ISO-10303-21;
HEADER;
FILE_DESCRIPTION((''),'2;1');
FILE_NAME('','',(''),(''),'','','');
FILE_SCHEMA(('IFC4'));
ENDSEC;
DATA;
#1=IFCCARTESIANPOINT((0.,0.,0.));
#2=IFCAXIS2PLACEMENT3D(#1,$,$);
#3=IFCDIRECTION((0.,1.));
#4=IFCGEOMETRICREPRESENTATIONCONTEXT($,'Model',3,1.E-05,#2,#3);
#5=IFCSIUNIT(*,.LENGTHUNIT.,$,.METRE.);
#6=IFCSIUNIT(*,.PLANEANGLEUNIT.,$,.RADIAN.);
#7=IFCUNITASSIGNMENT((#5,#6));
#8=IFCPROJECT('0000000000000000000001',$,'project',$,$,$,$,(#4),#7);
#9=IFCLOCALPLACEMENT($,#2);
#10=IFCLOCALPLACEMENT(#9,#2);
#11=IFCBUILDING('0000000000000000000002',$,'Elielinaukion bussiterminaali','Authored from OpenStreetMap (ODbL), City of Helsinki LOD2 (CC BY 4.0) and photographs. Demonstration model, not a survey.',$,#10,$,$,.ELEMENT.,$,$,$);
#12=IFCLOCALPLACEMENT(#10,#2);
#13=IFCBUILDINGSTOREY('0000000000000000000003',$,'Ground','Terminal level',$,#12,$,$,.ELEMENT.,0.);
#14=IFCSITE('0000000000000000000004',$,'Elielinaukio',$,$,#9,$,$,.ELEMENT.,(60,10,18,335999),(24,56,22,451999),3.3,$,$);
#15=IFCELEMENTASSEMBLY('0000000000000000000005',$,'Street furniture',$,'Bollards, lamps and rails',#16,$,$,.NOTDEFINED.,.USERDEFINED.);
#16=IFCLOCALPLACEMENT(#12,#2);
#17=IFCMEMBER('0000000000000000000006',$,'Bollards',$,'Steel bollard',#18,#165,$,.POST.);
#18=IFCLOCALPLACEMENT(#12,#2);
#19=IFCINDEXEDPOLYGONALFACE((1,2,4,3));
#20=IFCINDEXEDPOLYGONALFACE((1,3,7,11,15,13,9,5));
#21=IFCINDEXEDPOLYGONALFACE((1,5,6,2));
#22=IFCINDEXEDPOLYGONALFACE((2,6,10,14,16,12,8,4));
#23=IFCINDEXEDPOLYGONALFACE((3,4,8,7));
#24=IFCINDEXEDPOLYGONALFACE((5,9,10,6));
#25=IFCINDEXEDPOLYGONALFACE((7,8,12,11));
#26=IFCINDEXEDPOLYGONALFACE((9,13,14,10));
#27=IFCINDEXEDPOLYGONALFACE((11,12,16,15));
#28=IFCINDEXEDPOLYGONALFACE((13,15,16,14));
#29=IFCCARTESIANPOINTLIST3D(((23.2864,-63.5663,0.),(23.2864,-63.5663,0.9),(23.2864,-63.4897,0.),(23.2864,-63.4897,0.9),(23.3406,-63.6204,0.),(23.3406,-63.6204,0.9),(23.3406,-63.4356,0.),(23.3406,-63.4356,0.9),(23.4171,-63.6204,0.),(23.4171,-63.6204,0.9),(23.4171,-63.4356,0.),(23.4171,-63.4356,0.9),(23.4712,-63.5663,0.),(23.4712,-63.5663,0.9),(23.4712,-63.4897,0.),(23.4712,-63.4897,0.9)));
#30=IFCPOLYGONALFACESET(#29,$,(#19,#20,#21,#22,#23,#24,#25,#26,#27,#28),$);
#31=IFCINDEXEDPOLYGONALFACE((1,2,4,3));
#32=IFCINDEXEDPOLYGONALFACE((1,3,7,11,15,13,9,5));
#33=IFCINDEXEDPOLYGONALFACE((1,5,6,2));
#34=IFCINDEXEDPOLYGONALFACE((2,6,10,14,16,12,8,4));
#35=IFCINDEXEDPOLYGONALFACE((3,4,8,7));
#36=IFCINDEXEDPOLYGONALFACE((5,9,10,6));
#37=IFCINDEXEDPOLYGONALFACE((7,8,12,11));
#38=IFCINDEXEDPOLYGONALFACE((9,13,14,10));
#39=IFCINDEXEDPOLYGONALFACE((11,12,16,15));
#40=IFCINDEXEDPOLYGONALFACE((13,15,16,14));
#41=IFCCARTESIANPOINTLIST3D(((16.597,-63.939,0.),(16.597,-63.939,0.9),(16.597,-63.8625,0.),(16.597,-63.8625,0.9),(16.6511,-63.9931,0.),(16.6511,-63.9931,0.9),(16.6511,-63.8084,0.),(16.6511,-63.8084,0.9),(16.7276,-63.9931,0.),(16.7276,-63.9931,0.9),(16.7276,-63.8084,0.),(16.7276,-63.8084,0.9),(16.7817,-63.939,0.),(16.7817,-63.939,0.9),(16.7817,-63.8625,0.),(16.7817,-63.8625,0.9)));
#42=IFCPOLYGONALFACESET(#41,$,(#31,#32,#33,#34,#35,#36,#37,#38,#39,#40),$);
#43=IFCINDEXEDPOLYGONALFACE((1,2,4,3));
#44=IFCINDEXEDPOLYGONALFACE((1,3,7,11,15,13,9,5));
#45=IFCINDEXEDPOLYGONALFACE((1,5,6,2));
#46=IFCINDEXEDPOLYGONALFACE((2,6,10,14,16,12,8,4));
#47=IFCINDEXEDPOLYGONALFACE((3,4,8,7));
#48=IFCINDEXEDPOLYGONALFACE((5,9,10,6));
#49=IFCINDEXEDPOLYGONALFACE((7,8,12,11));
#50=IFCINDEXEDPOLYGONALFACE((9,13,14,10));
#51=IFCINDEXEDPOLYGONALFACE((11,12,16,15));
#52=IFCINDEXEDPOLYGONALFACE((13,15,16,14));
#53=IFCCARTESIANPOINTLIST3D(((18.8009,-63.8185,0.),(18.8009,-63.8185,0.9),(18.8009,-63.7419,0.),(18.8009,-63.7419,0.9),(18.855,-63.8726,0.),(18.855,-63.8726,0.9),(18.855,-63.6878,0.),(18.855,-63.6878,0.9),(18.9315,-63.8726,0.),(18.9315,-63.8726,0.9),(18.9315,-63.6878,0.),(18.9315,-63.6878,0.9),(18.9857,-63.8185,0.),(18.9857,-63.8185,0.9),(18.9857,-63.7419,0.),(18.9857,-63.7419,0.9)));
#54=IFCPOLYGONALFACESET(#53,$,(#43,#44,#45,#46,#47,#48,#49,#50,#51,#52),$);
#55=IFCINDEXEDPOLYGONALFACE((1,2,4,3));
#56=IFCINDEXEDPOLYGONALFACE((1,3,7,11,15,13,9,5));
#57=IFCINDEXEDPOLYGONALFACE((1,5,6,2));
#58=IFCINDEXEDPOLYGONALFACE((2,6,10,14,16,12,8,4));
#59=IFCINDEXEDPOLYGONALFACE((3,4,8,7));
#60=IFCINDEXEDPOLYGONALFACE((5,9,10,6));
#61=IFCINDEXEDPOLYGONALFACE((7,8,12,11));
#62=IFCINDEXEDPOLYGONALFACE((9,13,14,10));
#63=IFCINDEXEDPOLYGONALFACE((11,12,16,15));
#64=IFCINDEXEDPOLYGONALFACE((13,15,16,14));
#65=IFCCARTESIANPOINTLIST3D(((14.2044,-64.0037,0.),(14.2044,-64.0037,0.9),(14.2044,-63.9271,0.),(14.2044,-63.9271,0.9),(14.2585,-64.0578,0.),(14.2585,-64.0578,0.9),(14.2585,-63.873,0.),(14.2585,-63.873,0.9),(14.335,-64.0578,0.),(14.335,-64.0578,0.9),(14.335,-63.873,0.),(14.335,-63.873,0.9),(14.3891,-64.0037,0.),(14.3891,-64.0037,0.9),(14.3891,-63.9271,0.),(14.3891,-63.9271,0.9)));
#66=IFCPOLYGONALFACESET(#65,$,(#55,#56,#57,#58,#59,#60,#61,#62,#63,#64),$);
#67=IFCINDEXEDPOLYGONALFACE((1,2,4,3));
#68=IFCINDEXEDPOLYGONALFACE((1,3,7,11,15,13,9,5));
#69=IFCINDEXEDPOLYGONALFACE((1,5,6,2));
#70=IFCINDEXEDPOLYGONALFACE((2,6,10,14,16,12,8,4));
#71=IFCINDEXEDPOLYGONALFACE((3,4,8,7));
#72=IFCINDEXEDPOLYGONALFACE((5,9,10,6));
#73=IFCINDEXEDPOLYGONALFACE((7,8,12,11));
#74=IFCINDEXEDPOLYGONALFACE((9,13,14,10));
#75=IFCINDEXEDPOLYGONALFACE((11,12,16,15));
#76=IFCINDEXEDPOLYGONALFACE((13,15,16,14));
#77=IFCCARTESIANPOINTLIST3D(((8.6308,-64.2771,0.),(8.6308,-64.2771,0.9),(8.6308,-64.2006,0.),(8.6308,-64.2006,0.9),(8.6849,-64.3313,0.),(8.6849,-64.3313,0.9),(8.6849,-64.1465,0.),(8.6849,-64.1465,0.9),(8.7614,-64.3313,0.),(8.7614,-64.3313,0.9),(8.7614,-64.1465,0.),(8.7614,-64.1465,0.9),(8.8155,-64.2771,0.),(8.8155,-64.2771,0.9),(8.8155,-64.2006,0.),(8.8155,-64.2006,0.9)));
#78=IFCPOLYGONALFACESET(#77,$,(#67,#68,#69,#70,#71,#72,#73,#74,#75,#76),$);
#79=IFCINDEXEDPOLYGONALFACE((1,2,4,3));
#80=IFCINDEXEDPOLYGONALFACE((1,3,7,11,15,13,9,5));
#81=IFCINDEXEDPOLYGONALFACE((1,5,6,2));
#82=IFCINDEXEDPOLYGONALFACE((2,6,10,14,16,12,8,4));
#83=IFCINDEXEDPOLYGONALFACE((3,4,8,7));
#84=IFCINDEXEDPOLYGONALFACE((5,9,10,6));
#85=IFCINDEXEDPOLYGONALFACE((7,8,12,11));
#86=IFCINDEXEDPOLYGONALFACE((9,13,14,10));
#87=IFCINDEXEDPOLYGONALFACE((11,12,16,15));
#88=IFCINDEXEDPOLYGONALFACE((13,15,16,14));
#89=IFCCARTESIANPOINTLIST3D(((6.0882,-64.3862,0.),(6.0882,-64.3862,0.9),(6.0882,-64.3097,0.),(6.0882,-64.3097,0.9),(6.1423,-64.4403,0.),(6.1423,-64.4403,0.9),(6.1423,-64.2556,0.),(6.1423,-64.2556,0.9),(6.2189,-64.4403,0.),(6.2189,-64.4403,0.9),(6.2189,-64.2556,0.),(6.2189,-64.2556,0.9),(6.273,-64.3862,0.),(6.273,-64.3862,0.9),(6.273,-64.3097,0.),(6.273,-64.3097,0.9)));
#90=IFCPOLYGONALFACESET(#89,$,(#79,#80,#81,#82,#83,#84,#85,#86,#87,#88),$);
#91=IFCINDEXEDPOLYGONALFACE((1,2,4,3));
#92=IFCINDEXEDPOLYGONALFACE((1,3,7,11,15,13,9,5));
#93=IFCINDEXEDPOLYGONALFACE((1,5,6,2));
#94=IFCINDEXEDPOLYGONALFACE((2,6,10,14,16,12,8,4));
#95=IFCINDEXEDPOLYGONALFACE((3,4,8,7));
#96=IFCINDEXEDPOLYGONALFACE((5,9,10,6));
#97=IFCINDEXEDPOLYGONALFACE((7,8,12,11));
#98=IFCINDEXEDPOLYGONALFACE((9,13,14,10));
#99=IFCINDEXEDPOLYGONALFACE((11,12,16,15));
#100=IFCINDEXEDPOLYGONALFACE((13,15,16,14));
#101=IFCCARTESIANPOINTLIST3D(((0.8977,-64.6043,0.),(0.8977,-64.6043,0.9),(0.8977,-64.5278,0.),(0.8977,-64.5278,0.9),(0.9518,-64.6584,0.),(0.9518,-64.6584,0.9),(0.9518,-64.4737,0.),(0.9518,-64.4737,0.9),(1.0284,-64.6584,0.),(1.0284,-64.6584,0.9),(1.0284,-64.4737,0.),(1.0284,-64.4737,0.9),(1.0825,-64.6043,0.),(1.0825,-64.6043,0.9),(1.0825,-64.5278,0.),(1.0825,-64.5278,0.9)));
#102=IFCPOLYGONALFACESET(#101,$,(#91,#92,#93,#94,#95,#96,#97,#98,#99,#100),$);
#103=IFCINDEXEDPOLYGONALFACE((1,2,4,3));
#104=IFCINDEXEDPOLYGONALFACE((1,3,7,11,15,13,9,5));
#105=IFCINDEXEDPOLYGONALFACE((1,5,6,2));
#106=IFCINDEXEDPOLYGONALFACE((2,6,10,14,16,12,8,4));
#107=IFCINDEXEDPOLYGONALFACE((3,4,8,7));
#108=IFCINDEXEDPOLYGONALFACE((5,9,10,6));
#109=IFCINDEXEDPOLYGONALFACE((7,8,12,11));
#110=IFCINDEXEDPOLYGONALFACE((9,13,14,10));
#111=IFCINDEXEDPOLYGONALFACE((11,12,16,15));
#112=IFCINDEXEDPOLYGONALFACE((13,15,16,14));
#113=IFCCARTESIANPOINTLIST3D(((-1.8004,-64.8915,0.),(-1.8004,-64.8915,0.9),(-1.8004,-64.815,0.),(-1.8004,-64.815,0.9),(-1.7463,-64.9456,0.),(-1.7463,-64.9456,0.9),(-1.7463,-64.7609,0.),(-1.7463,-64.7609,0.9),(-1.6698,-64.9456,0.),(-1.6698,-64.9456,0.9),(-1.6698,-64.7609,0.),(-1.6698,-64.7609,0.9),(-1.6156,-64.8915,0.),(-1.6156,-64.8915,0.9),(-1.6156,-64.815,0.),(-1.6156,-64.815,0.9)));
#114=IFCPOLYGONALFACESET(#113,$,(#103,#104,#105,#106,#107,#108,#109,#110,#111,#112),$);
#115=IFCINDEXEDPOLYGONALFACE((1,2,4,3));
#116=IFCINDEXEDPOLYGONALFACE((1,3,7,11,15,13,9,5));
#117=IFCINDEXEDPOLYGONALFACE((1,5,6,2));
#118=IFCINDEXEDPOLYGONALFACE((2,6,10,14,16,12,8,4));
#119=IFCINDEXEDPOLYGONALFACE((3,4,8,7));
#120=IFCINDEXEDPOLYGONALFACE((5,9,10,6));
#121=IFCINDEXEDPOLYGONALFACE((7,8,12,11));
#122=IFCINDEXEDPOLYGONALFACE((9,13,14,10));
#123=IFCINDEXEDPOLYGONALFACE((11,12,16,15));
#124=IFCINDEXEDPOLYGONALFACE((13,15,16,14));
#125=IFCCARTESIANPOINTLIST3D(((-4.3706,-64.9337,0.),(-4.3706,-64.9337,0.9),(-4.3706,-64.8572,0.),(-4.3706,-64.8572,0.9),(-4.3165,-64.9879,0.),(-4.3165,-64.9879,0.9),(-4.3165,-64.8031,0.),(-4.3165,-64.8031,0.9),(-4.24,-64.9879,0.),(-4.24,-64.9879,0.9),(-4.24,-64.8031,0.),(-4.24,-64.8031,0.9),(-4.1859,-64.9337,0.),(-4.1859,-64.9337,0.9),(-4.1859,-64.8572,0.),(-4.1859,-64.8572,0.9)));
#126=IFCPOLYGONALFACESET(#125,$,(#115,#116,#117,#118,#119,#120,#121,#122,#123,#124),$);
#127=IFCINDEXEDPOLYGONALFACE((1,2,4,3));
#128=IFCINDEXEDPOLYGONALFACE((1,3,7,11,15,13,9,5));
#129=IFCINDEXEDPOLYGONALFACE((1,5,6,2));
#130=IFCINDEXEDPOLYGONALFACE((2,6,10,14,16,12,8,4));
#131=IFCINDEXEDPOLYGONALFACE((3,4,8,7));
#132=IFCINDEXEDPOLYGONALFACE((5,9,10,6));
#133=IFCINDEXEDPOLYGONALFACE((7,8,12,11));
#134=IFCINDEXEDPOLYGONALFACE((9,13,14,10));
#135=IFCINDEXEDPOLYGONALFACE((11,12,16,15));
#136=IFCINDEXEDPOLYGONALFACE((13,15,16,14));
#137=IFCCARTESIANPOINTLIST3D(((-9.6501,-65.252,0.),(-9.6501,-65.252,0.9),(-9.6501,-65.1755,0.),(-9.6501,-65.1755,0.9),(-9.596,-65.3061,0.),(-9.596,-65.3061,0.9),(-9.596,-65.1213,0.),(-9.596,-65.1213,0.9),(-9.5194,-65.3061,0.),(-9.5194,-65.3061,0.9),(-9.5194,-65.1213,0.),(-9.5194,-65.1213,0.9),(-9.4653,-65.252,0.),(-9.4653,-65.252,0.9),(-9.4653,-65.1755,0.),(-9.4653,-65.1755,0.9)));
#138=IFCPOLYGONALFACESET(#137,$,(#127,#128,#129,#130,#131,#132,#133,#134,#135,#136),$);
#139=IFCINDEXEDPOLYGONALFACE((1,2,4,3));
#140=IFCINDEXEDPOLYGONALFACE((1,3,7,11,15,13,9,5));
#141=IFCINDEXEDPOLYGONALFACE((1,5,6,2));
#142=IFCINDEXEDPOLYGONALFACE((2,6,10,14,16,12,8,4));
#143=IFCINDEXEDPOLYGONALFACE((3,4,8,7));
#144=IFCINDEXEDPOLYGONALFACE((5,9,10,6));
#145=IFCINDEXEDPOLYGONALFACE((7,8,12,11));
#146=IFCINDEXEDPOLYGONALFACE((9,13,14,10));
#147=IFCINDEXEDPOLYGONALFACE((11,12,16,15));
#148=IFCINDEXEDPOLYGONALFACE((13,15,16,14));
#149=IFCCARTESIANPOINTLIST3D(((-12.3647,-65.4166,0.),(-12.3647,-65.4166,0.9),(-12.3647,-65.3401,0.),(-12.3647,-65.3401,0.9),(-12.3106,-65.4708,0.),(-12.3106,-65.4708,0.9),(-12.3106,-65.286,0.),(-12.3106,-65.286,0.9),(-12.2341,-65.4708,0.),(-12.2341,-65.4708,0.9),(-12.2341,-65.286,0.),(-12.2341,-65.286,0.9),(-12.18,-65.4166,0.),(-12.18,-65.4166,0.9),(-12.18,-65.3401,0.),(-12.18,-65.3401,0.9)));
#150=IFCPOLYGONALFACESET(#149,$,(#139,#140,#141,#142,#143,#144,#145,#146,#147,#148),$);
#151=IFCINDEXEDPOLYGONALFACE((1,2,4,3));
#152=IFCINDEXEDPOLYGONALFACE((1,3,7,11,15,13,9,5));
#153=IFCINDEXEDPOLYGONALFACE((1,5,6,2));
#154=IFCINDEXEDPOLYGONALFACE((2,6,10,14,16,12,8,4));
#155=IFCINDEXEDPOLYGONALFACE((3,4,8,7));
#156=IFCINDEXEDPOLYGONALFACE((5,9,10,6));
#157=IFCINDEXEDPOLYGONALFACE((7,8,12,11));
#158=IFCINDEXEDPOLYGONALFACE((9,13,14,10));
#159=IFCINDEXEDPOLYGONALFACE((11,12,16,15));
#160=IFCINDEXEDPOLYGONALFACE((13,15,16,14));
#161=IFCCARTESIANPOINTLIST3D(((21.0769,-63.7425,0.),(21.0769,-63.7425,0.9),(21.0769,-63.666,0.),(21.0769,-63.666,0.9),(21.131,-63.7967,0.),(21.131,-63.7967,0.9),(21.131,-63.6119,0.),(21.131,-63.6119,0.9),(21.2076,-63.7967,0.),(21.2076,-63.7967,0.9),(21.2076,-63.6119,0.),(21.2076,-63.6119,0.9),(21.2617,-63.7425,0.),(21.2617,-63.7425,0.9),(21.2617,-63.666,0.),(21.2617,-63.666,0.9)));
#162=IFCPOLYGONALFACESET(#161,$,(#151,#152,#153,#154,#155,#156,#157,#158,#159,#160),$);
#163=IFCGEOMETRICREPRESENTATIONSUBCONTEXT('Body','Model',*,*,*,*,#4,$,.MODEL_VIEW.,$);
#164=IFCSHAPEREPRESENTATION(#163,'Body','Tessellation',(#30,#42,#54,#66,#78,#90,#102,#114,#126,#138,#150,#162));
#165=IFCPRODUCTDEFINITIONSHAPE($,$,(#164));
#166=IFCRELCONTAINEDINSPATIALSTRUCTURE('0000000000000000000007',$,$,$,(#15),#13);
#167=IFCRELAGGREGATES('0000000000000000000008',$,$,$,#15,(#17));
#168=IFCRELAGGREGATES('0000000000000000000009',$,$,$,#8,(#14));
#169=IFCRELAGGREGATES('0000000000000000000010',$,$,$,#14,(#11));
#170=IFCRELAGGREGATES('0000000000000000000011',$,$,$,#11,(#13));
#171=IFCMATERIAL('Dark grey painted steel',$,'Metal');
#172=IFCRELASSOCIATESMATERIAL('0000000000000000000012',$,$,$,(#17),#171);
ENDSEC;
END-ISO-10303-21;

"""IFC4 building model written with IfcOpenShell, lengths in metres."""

from ifc_helpers import new_model, si_unit, direction, origin, place, context, subcontext, project, spatial, polyline, outline, extrude, material, element, aggregate, save


model = new_model("IFC4")

# Units and contexts
model_context = context("Model", 3, precision=1e-05, world=origin(), true_north=direction((0.0, 1.0)))
body_context = subcontext(model_context, "Body", "Model", "MODEL_VIEW")
ifc_project = project(units=[si_unit("LENGTHUNIT", "METRE"), si_unit("PLANEANGLEUNIT", "RADIAN")], contexts=[model_context])

# Site, building, storey
site_placement = place(None, origin())
site = spatial("IfcSite", under=ifc_project, at=site_placement, Name="Elielinaukio", CompositionType="ELEMENT", RefLatitude=(60, 10, 18, 335999), RefLongitude=(24, 56, 22, 451999), RefElevation=3.3)
building_placement = place(site_placement, origin())
building = spatial("IfcBuilding", under=site, at=building_placement, Name="Elielinaukion bussiterminaali", Description="Authored from OpenStreetMap (ODbL), City of Helsinki LOD2 (CC BY 4.0) and photographs. Demonstration model, not a survey.", CompositionType="ELEMENT")
storey_placement = place(building_placement, origin())
storey = spatial("IfcBuildingStorey", under=building, at=storey_placement, Name="Ground", Description="Terminal level", CompositionType="ELEMENT", Elevation=0.0)

# Shared definitions
ifc_material_1 = material(Name="Dark grey painted steel", Category="Metal")

# Element assembly, member
assembly_1_placement = place(building_placement, origin())
assembly_1 = element("IfcElementAssembly", 1, at=assembly_1_placement, inside=storey, Name="Street furniture", ObjectType="Bollards, lamps and rails", AssemblyPlace="NOTDEFINED", PredefinedType="USERDEFINED")
member_1_placement = place(building_placement, origin())
member_1 = element("IfcMember", 2, at=member_1_placement, material=ifc_material_1, Name="Bollards", ObjectType="Steel bollard", PredefinedType="POST", context=body_context, shape_type="SweptSolid", body=[
    extrude(outline(polyline([(23.4712, -63.4897), (23.4171, -63.4356), (23.3406, -63.4356), (23.2864, -63.4897), (23.2864, -63.5663), (23.3406, -63.6204), (23.4171, -63.6204), (23.4712, -63.5663), (23.4712, -63.4897)])), origin(), (0.0, 0.0, 1.0), 0.9),
    extrude(outline(polyline([(16.7817, -63.8625), (16.7276, -63.8084), (16.6511, -63.8084), (16.597, -63.8625), (16.597, -63.939), (16.6511, -63.9931), (16.7276, -63.9931), (16.7817, -63.939), (16.7817, -63.8625)])), origin(), (0.0, 0.0, 1.0), 0.9),
    extrude(outline(polyline([(18.9857, -63.7419), (18.9315, -63.6878), (18.855, -63.6878), (18.8009, -63.7419), (18.8009, -63.8185), (18.855, -63.8726), (18.9315, -63.8726), (18.9857, -63.8185), (18.9857, -63.7419)])), origin(), (0.0, 0.0, 1.0), 0.9),
    extrude(outline(polyline([(14.3891, -63.9271), (14.335, -63.873), (14.2585, -63.873), (14.2044, -63.9271), (14.2044, -64.0037), (14.2585, -64.0578), (14.335, -64.0578), (14.3891, -64.0037), (14.3891, -63.9271)])), origin(), (0.0, 0.0, 1.0), 0.9),
    extrude(outline(polyline([(8.8155, -64.2006), (8.7614, -64.1465), (8.6849, -64.1465), (8.6308, -64.2006), (8.6308, -64.2771), (8.6849, -64.3313), (8.7614, -64.3313), (8.8155, -64.2771), (8.8155, -64.2006)])), origin(), (0.0, 0.0, 1.0), 0.9),
    extrude(outline(polyline([(6.273, -64.3097), (6.2189, -64.2556), (6.1423, -64.2556), (6.0882, -64.3097), (6.0882, -64.3862), (6.1423, -64.4403), (6.2189, -64.4403), (6.273, -64.3862), (6.273, -64.3097)])), origin(), (0.0, 0.0, 1.0), 0.9),
    extrude(outline(polyline([(1.0825, -64.5278), (1.0284, -64.4737), (0.9518, -64.4737), (0.8977, -64.5278), (0.8977, -64.6043), (0.9518, -64.6584), (1.0284, -64.6584), (1.0825, -64.6043), (1.0825, -64.5278)])), origin(), (0.0, 0.0, 1.0), 0.9),
    extrude(outline(polyline([(-1.6156, -64.815), (-1.6698, -64.7609), (-1.7463, -64.7609), (-1.8004, -64.815), (-1.8004, -64.8915), (-1.7463, -64.9456), (-1.6698, -64.9456), (-1.6156, -64.8915), (-1.6156, -64.815)])), origin(), (0.0, 0.0, 1.0), 0.9),
    extrude(outline(polyline([(-4.1859, -64.8572), (-4.24, -64.8031), (-4.3165, -64.8031), (-4.3706, -64.8572), (-4.3706, -64.9337), (-4.3165, -64.9879), (-4.24, -64.9879), (-4.1859, -64.9337), (-4.1859, -64.8572)])), origin(), (0.0, 0.0, 1.0), 0.9),
    extrude(outline(polyline([(-9.4653, -65.1755), (-9.5194, -65.1213), (-9.596, -65.1213), (-9.6501, -65.1755), (-9.6501, -65.252), (-9.596, -65.3061), (-9.5194, -65.3061), (-9.4653, -65.252), (-9.4653, -65.1755)])), origin(), (0.0, 0.0, 1.0), 0.9),
    extrude(outline(polyline([(-12.18, -65.3401), (-12.2341, -65.286), (-12.3106, -65.286), (-12.3647, -65.3401), (-12.3647, -65.4166), (-12.3106, -65.4708), (-12.2341, -65.4708), (-12.18, -65.4166), (-12.18, -65.3401)])), origin(), (0.0, 0.0, 1.0), 0.9),
    extrude(outline(polyline([(21.2617, -63.666), (21.2076, -63.6119), (21.131, -63.6119), (21.0769, -63.666), (21.0769, -63.7425), (21.131, -63.7967), (21.2076, -63.7967), (21.2617, -63.7425), (21.2617, -63.666)])), origin(), (0.0, 0.0, 1.0), 0.9),
])

aggregate(assembly_1, [member_1])

save(model, "model.ifc")
